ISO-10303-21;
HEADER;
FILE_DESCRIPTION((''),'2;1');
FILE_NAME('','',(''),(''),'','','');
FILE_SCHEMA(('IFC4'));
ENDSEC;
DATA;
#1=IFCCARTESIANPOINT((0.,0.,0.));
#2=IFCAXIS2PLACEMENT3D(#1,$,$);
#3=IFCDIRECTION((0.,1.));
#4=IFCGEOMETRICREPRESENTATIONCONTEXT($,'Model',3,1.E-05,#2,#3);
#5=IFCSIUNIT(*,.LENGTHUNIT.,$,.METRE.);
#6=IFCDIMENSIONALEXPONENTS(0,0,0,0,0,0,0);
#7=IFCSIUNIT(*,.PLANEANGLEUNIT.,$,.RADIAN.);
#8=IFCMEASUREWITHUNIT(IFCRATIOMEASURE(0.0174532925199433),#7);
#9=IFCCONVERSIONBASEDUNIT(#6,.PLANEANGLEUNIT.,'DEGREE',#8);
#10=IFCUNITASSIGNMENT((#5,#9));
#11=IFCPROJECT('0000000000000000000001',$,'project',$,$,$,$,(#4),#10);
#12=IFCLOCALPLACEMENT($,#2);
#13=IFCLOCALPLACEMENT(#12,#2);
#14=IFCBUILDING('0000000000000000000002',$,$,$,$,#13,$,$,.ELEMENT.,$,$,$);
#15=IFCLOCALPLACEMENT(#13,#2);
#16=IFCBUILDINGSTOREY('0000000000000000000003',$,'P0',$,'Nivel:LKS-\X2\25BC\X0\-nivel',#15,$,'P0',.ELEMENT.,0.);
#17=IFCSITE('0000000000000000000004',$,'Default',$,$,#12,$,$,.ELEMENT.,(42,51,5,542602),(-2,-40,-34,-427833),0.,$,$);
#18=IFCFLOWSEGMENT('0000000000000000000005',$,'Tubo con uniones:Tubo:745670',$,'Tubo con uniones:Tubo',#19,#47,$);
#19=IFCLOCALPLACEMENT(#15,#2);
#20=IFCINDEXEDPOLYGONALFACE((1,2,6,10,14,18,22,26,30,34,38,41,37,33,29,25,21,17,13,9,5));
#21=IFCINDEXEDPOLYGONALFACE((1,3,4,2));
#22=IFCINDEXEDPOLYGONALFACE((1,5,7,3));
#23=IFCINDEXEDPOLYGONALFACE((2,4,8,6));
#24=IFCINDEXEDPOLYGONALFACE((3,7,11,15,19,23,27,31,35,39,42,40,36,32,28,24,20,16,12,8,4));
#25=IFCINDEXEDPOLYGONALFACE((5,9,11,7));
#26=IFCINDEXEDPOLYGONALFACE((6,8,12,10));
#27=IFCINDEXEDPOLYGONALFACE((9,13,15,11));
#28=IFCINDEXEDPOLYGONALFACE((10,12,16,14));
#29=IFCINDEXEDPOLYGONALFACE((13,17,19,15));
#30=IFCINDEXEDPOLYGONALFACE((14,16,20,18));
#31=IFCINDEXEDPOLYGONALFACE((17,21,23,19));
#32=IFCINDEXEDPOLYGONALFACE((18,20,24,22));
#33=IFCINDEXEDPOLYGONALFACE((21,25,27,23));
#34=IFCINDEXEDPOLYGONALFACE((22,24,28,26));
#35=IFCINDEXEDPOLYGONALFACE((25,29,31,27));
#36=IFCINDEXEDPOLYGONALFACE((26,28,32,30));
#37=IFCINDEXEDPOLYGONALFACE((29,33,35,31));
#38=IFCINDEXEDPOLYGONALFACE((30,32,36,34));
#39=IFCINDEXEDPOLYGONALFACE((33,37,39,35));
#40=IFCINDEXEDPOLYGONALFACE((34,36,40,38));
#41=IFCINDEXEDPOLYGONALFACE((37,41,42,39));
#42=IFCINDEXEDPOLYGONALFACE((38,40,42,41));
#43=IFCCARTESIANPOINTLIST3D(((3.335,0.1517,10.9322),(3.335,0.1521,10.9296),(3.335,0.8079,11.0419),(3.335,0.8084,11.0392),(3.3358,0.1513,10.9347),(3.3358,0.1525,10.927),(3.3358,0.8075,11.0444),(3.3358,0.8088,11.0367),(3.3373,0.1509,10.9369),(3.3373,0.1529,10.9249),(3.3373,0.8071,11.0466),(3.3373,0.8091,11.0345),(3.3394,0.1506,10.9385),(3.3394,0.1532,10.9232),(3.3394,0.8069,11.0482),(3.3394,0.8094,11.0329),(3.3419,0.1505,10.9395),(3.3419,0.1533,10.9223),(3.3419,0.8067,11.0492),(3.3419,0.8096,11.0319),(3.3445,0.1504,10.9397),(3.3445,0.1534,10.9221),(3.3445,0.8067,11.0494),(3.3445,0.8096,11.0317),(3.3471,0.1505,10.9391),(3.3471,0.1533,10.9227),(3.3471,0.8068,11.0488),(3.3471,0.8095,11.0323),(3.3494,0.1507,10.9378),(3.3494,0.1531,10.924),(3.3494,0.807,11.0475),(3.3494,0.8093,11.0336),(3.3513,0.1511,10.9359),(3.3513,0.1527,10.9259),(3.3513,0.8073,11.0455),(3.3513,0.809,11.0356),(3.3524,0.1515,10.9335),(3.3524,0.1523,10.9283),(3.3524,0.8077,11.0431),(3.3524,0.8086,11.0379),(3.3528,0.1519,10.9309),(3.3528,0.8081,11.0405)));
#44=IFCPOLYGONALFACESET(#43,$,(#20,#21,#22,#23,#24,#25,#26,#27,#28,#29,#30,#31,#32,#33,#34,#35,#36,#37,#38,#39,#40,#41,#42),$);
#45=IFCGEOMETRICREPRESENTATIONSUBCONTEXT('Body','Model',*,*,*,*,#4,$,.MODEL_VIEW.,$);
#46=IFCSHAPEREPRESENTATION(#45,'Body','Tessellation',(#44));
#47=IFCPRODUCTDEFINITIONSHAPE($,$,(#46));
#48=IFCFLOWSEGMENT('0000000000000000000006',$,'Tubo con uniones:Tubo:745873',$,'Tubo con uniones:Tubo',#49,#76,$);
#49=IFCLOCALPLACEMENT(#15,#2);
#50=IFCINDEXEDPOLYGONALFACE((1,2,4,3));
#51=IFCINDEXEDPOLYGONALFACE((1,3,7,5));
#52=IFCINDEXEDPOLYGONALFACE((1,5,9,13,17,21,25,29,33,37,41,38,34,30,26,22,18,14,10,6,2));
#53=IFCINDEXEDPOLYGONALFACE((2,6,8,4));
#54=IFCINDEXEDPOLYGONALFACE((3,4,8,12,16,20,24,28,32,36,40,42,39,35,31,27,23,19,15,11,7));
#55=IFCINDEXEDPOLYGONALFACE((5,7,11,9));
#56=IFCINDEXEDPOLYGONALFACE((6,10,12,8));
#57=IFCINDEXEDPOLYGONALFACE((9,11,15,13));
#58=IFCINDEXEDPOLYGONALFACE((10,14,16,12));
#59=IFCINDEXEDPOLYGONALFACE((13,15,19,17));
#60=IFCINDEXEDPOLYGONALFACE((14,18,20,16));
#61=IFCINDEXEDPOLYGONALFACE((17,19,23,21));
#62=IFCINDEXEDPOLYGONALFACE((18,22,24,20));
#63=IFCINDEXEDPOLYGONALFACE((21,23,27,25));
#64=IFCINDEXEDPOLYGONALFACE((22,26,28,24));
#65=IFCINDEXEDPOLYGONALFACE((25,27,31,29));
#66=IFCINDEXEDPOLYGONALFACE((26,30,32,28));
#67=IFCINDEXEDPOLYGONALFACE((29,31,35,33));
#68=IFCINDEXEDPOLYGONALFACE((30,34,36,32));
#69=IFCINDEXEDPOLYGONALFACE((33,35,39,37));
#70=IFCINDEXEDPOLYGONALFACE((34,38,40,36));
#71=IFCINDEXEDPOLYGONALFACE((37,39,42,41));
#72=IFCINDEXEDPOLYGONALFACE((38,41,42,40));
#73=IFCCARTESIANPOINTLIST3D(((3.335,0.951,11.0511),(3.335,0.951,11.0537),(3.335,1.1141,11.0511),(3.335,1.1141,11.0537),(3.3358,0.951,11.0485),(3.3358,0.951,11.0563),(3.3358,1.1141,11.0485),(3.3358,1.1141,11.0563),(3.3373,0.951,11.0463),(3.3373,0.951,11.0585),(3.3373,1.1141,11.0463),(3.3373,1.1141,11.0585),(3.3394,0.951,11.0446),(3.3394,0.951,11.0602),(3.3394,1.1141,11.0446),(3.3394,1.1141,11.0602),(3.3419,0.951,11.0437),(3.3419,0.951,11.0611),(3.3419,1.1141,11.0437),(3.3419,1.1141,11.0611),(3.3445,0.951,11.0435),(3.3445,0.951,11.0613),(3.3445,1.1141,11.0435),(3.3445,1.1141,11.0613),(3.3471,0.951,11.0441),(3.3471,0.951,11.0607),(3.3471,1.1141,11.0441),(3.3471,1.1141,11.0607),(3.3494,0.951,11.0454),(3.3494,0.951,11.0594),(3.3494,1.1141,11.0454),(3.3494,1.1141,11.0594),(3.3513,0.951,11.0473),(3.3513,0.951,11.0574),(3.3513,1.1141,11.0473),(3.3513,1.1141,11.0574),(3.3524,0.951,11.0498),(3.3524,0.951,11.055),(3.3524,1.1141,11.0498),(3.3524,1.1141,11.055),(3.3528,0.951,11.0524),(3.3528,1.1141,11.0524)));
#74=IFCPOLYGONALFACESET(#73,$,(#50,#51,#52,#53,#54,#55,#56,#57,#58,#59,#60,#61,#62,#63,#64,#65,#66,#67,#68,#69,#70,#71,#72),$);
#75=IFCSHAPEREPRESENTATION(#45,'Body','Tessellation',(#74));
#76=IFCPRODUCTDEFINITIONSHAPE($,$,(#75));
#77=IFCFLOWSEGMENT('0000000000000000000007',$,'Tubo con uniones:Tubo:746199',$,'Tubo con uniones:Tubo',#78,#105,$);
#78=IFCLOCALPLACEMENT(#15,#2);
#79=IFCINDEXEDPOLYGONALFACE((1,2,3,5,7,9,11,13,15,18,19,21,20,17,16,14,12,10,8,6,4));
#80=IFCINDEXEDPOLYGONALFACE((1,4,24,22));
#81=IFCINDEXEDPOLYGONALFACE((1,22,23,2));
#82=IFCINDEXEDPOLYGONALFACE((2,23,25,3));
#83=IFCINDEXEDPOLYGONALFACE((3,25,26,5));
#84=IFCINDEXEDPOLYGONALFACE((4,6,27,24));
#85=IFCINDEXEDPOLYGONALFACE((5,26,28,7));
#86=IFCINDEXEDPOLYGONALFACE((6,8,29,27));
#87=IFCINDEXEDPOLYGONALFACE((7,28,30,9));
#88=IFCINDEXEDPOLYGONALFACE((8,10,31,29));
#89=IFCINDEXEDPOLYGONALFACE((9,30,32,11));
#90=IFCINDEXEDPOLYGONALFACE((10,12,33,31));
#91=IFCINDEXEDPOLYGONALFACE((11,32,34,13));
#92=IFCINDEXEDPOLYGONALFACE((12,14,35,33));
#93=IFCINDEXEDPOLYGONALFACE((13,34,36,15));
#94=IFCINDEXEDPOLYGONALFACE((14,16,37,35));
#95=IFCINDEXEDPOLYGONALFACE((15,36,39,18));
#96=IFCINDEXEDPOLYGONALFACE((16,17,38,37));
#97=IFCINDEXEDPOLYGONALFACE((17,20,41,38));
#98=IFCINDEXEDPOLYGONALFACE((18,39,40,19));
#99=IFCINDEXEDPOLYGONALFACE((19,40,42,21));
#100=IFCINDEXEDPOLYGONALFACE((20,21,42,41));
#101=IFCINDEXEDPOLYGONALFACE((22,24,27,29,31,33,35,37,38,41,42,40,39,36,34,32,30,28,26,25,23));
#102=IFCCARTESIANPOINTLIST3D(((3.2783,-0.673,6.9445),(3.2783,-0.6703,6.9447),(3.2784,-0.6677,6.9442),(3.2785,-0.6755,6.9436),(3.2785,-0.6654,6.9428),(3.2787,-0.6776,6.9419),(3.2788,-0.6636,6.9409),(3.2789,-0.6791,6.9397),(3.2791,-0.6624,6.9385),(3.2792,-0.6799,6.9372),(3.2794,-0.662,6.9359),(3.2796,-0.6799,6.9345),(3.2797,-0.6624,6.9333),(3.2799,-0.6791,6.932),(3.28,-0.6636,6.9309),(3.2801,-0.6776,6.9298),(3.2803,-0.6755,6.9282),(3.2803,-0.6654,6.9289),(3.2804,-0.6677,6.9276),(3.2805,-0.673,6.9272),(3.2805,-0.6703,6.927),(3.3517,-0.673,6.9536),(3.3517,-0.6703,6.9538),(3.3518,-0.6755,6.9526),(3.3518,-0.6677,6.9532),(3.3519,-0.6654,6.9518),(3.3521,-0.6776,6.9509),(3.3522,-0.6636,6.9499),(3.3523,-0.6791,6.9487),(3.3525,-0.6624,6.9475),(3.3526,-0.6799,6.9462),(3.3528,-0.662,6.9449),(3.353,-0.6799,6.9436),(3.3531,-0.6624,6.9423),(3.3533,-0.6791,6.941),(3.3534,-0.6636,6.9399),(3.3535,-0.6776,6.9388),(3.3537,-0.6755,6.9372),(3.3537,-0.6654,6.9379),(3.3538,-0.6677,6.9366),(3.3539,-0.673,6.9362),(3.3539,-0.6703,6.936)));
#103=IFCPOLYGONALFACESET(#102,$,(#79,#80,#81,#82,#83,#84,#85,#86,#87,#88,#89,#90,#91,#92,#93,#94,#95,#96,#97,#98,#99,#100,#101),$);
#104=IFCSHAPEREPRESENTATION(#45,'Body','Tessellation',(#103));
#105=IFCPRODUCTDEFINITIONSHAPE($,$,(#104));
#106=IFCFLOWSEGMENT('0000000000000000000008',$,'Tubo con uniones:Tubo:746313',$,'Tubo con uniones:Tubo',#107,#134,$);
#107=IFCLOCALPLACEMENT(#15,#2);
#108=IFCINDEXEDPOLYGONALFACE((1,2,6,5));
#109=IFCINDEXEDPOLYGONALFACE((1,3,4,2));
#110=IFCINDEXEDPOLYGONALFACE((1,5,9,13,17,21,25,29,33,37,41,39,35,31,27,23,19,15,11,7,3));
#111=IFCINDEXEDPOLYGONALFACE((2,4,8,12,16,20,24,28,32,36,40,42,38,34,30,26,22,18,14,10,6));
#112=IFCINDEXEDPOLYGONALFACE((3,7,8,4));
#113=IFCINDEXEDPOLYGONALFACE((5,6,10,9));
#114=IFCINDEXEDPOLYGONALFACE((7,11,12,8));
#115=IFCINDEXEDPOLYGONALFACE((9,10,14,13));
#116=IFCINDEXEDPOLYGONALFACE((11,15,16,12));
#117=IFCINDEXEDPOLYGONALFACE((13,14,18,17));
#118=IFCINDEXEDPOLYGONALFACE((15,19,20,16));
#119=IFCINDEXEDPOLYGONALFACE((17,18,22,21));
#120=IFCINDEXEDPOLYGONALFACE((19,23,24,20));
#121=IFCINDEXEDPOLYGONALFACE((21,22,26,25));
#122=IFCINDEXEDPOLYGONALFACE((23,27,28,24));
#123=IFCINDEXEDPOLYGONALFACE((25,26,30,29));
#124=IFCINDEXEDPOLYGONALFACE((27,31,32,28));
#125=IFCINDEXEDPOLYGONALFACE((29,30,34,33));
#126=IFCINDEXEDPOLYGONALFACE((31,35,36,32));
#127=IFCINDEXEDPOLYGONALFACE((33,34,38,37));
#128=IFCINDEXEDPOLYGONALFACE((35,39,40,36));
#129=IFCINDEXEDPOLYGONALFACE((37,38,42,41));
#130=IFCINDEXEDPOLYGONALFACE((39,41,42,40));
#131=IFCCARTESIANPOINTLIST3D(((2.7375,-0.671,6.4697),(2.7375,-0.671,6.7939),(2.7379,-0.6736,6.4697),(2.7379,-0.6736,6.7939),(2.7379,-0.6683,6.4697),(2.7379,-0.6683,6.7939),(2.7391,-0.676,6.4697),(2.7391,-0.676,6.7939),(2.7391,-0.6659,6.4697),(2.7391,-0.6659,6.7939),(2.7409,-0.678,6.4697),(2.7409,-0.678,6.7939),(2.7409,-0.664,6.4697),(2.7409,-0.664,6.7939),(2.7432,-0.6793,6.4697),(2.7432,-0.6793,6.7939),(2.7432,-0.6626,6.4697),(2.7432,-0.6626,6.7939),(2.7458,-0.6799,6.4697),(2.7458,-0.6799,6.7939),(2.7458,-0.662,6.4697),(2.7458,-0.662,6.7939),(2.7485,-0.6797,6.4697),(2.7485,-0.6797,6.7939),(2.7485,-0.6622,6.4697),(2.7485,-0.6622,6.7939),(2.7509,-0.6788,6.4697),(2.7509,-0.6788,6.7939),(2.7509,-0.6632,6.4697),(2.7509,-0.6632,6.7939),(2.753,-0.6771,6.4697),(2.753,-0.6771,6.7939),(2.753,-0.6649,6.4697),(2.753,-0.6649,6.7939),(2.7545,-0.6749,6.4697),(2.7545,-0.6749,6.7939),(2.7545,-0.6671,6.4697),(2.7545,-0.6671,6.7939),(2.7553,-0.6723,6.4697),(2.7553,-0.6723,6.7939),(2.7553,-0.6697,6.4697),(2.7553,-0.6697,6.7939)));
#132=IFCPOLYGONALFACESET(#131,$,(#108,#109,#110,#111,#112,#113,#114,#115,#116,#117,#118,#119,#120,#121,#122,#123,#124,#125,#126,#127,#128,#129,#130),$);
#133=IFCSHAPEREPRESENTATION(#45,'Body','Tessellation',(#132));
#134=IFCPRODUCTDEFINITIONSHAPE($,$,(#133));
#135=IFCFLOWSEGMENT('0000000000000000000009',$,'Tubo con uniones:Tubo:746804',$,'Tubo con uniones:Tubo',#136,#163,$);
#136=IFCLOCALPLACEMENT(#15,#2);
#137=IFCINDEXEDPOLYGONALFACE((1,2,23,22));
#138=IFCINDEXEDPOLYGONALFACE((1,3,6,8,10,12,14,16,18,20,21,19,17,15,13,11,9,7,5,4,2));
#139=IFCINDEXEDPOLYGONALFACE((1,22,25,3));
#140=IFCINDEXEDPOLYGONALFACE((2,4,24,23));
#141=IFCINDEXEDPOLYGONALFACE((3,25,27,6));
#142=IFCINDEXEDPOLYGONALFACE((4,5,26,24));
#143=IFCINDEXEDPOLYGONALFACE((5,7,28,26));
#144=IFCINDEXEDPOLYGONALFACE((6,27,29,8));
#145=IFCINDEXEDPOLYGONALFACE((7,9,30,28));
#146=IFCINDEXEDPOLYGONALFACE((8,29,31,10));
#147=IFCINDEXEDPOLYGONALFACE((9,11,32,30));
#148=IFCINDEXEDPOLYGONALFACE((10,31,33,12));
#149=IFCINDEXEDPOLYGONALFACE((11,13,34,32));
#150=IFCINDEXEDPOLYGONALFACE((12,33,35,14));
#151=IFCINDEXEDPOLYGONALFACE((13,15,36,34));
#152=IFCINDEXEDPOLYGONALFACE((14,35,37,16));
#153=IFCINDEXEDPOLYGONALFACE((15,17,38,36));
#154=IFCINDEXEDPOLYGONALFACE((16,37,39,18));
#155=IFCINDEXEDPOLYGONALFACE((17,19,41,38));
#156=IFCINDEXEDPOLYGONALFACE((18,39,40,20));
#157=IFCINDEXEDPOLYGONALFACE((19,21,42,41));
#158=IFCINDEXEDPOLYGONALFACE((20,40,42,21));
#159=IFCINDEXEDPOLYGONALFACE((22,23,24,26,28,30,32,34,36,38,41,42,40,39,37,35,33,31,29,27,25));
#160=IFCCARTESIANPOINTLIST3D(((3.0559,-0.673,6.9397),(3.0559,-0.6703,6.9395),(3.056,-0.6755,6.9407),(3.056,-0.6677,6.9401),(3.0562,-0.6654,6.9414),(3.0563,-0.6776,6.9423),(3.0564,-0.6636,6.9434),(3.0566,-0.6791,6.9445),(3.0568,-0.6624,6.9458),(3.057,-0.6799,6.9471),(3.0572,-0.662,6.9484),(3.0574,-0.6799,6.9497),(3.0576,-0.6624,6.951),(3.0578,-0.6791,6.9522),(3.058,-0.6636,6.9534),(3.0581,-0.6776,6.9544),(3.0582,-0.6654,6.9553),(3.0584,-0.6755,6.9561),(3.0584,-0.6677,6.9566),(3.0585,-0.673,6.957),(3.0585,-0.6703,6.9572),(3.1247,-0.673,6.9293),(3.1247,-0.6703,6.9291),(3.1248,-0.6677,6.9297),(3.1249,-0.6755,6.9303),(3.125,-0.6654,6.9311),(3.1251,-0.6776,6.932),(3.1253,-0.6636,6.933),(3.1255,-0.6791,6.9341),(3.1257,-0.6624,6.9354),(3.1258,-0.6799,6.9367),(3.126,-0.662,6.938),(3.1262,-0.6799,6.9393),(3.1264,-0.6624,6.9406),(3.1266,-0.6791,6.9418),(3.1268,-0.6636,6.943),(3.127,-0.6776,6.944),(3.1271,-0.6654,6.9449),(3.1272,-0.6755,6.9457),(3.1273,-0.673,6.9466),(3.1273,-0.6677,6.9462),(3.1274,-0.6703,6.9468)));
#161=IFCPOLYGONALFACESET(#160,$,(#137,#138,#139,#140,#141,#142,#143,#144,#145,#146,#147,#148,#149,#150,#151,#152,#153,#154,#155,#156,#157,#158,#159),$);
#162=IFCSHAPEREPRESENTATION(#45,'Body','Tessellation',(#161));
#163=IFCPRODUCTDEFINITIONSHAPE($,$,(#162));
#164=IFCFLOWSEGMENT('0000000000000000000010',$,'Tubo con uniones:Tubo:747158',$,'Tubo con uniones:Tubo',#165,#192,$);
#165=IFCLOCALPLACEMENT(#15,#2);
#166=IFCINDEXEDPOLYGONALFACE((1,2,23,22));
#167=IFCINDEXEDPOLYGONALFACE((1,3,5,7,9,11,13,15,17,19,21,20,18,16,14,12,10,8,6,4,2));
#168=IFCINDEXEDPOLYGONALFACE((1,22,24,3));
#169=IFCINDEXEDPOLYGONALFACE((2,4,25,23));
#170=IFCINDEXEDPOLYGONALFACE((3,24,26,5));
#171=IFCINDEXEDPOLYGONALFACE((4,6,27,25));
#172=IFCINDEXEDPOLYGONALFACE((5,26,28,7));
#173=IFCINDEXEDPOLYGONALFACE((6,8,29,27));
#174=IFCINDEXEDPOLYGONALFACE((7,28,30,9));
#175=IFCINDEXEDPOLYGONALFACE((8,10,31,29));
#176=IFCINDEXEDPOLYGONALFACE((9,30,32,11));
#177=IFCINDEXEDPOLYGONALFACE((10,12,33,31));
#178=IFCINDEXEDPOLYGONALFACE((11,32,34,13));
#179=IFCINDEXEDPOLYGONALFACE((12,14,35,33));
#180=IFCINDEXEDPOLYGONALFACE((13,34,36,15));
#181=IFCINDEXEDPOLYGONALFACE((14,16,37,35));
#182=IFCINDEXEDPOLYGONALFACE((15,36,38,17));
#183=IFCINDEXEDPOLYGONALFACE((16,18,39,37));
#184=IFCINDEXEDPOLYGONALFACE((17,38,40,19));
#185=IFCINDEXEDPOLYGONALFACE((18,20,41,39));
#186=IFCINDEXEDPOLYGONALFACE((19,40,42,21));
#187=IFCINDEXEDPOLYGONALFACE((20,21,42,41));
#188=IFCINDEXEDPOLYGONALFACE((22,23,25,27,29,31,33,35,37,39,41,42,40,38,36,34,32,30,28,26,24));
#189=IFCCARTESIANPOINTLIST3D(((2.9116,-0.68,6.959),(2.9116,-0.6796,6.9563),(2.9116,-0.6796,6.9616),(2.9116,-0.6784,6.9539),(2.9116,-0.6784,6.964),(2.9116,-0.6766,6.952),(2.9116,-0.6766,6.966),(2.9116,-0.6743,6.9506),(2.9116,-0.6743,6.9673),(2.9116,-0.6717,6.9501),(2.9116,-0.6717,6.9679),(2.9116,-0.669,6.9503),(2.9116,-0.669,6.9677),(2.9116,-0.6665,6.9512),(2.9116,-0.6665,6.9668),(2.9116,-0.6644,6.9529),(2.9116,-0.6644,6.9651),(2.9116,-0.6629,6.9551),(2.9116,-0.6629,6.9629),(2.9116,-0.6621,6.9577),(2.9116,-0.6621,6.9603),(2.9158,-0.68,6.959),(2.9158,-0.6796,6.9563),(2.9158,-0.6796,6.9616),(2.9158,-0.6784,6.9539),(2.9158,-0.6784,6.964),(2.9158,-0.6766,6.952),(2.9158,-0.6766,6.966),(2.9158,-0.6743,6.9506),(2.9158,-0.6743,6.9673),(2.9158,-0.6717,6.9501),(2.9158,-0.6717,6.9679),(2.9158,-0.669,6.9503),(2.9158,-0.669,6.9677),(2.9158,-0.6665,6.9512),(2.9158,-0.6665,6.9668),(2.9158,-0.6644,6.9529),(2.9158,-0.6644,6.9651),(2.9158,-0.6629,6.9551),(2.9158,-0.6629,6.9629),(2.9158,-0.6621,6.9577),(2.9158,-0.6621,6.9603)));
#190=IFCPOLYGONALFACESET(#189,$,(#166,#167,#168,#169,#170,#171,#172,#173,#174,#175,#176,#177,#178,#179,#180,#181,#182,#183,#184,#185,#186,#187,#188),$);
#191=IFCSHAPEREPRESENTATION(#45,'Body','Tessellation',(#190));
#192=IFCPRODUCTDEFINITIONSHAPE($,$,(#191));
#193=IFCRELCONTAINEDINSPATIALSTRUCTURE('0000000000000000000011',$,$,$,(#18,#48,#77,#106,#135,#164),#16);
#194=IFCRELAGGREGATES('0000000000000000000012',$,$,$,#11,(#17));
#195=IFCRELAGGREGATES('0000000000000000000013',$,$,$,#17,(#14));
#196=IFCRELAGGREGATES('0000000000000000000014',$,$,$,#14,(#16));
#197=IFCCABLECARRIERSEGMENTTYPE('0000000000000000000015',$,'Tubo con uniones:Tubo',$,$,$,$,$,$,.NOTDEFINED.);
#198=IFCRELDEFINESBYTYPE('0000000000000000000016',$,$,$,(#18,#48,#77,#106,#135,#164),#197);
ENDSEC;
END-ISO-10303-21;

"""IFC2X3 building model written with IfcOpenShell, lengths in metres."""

from ifc_helpers import new_model, entity, si_unit, converted_unit, direction, frame, frame_2d, origin, origin_2d_with_axis, place, context, subcontext, project, spatial, circle, extrude, type_object, element, save


model = new_model("IFC2X3")

# Units and contexts
model_context = context("Model", 3, precision=1e-05, world=origin(), true_north=direction((0.0, 1.0)))
body_context = subcontext(model_context, "Body", "Model", "MODEL_VIEW")
ifc_project = project(units=[si_unit("LENGTHUNIT", "METRE"), converted_unit("PLANEANGLEUNIT", "DEGREE", entity("IfcRatioMeasure", 0.0174532925199433), si_unit("PLANEANGLEUNIT", "RADIAN"), dimensions=[0, 0, 0, 0, 0, 0, 0])], contexts=[model_context])

# Site, building, storey
site_placement = place(None, origin())
site = spatial("IfcSite", under=ifc_project, at=site_placement, Name="Default", CompositionType="ELEMENT", RefLatitude=(42, 51, 5, 542602), RefLongitude=(-2, -40, -34, -427833), RefElevation=0.0)
building_placement = place(site_placement, origin())
building = spatial("IfcBuilding", under=site, at=building_placement, CompositionType="ELEMENT")
storey_placement = place(building_placement, origin())
storey = spatial("IfcBuildingStorey", under=building, at=storey_placement, Name="P0", ObjectType="Nivel:LKS-▼-nivel", LongName="P0", CompositionType="ELEMENT", Elevation=0.0)

# Flow segments
cable_carrier_segment_type = type_object("IfcCableCarrierSegmentType", Name="Tubo con uniones:Tubo", PredefinedType="NOTDEFINED")
flow_segment_1_placement = place(storey_placement, origin())
element("IfcFlowSegment", 1, at=flow_segment_1_placement, inside=storey, type_object=cable_carrier_segment_type, Name="Tubo con uniones:Tubo:745670", ObjectType="Tubo con uniones:Tubo", context=body_context, shape_type="SweptSolid", body=[
    extrude(circle(Radius=0.009, at=frame_2d((0.0, 0.0), x_axis=(1.0, 0.0))), frame((3.3439, 0.1519, 10.9309), z_axis=(0.0, 0.986324, 0.16482), x_axis=(1.0, 0.0, 0.0)), (0.0, 0.0, 1.0), 0.6653),
])
flow_segment_2_placement = place(storey_placement, origin())
element("IfcFlowSegment", 2, at=flow_segment_2_placement, inside=storey, type_object=cable_carrier_segment_type, Name="Tubo con uniones:Tubo:745873", ObjectType="Tubo con uniones:Tubo", context=body_context, shape_type="SweptSolid", body=[
    extrude(circle(Radius=0.009, at=frame_2d((0.0, 0.0), x_axis=(1.0, 0.0))), frame((3.3439, 0.951, 11.0524), z_axis=(0.0, 1.0, 0.0), x_axis=(1.0, 0.0, 0.0)), (0.0, 0.0, 1.0), 0.1631),
])
flow_segment_3_placement = place(storey_placement, origin())
element("IfcFlowSegment", 3, at=flow_segment_3_placement, inside=storey, type_object=cable_carrier_segment_type, Name="Tubo con uniones:Tubo:746199", ObjectType="Tubo con uniones:Tubo", context=body_context, shape_type="SweptSolid", body=[
    extrude(circle(Radius=0.009, at=frame_2d((0.0, 0.0), x_axis=(1.0, 0.0))), frame((3.2794, -0.671, 6.9359), z_axis=(0.992546, 0.0, 0.121869), x_axis=(0.0, 1.0, 0.0)), (0.0, 0.0, 1.0), 0.0739),
])
flow_segment_4_placement = place(storey_placement, origin())
element("IfcFlowSegment", 4, at=flow_segment_4_placement, inside=storey, type_object=cable_carrier_segment_type, Name="Tubo con uniones:Tubo:746313", ObjectType="Tubo con uniones:Tubo", context=body_context, shape_type="SweptSolid", body=[
    extrude(circle(Radius=0.009, at=origin_2d_with_axis()), frame((2.7465, -0.671, 6.4697), z_axis=(0.0, 0.0, 1.0), x_axis=(-1.0, 0.0, 0.0)), (0.0, 0.0, 1.0), 0.3242),
])
flow_segment_5_placement = place(storey_placement, origin())
element("IfcFlowSegment", 5, at=flow_segment_5_placement, inside=storey, type_object=cable_carrier_segment_type, Name="Tubo con uniones:Tubo:746804", ObjectType="Tubo con uniones:Tubo", context=body_context, shape_type="SweptSolid", body=[
    extrude(circle(Radius=0.009, at=frame_2d((0.0, 0.0), x_axis=(1.0, 0.0))), frame((3.0572, -0.671, 6.9484), z_axis=(0.988805, 0.0, -0.149211), x_axis=(0.0, 1.0, 0.0)), (0.0, 0.0, 1.0), 0.0696),
])
flow_segment_6_placement = place(storey_placement, origin())
element("IfcFlowSegment", 6, at=flow_segment_6_placement, inside=storey, type_object=cable_carrier_segment_type, Name="Tubo con uniones:Tubo:747158", ObjectType="Tubo con uniones:Tubo", context=body_context, shape_type="SweptSolid", body=[
    extrude(circle(Radius=0.009, at=origin_2d_with_axis()), frame((2.9116, -0.671, 6.959), z_axis=(1.0, 0.0, 0.0), x_axis=(0.0, -1.0, 0.0)), (0.0, 0.0, 1.0), 0.0042),
])

save(model, "model.ifc")
